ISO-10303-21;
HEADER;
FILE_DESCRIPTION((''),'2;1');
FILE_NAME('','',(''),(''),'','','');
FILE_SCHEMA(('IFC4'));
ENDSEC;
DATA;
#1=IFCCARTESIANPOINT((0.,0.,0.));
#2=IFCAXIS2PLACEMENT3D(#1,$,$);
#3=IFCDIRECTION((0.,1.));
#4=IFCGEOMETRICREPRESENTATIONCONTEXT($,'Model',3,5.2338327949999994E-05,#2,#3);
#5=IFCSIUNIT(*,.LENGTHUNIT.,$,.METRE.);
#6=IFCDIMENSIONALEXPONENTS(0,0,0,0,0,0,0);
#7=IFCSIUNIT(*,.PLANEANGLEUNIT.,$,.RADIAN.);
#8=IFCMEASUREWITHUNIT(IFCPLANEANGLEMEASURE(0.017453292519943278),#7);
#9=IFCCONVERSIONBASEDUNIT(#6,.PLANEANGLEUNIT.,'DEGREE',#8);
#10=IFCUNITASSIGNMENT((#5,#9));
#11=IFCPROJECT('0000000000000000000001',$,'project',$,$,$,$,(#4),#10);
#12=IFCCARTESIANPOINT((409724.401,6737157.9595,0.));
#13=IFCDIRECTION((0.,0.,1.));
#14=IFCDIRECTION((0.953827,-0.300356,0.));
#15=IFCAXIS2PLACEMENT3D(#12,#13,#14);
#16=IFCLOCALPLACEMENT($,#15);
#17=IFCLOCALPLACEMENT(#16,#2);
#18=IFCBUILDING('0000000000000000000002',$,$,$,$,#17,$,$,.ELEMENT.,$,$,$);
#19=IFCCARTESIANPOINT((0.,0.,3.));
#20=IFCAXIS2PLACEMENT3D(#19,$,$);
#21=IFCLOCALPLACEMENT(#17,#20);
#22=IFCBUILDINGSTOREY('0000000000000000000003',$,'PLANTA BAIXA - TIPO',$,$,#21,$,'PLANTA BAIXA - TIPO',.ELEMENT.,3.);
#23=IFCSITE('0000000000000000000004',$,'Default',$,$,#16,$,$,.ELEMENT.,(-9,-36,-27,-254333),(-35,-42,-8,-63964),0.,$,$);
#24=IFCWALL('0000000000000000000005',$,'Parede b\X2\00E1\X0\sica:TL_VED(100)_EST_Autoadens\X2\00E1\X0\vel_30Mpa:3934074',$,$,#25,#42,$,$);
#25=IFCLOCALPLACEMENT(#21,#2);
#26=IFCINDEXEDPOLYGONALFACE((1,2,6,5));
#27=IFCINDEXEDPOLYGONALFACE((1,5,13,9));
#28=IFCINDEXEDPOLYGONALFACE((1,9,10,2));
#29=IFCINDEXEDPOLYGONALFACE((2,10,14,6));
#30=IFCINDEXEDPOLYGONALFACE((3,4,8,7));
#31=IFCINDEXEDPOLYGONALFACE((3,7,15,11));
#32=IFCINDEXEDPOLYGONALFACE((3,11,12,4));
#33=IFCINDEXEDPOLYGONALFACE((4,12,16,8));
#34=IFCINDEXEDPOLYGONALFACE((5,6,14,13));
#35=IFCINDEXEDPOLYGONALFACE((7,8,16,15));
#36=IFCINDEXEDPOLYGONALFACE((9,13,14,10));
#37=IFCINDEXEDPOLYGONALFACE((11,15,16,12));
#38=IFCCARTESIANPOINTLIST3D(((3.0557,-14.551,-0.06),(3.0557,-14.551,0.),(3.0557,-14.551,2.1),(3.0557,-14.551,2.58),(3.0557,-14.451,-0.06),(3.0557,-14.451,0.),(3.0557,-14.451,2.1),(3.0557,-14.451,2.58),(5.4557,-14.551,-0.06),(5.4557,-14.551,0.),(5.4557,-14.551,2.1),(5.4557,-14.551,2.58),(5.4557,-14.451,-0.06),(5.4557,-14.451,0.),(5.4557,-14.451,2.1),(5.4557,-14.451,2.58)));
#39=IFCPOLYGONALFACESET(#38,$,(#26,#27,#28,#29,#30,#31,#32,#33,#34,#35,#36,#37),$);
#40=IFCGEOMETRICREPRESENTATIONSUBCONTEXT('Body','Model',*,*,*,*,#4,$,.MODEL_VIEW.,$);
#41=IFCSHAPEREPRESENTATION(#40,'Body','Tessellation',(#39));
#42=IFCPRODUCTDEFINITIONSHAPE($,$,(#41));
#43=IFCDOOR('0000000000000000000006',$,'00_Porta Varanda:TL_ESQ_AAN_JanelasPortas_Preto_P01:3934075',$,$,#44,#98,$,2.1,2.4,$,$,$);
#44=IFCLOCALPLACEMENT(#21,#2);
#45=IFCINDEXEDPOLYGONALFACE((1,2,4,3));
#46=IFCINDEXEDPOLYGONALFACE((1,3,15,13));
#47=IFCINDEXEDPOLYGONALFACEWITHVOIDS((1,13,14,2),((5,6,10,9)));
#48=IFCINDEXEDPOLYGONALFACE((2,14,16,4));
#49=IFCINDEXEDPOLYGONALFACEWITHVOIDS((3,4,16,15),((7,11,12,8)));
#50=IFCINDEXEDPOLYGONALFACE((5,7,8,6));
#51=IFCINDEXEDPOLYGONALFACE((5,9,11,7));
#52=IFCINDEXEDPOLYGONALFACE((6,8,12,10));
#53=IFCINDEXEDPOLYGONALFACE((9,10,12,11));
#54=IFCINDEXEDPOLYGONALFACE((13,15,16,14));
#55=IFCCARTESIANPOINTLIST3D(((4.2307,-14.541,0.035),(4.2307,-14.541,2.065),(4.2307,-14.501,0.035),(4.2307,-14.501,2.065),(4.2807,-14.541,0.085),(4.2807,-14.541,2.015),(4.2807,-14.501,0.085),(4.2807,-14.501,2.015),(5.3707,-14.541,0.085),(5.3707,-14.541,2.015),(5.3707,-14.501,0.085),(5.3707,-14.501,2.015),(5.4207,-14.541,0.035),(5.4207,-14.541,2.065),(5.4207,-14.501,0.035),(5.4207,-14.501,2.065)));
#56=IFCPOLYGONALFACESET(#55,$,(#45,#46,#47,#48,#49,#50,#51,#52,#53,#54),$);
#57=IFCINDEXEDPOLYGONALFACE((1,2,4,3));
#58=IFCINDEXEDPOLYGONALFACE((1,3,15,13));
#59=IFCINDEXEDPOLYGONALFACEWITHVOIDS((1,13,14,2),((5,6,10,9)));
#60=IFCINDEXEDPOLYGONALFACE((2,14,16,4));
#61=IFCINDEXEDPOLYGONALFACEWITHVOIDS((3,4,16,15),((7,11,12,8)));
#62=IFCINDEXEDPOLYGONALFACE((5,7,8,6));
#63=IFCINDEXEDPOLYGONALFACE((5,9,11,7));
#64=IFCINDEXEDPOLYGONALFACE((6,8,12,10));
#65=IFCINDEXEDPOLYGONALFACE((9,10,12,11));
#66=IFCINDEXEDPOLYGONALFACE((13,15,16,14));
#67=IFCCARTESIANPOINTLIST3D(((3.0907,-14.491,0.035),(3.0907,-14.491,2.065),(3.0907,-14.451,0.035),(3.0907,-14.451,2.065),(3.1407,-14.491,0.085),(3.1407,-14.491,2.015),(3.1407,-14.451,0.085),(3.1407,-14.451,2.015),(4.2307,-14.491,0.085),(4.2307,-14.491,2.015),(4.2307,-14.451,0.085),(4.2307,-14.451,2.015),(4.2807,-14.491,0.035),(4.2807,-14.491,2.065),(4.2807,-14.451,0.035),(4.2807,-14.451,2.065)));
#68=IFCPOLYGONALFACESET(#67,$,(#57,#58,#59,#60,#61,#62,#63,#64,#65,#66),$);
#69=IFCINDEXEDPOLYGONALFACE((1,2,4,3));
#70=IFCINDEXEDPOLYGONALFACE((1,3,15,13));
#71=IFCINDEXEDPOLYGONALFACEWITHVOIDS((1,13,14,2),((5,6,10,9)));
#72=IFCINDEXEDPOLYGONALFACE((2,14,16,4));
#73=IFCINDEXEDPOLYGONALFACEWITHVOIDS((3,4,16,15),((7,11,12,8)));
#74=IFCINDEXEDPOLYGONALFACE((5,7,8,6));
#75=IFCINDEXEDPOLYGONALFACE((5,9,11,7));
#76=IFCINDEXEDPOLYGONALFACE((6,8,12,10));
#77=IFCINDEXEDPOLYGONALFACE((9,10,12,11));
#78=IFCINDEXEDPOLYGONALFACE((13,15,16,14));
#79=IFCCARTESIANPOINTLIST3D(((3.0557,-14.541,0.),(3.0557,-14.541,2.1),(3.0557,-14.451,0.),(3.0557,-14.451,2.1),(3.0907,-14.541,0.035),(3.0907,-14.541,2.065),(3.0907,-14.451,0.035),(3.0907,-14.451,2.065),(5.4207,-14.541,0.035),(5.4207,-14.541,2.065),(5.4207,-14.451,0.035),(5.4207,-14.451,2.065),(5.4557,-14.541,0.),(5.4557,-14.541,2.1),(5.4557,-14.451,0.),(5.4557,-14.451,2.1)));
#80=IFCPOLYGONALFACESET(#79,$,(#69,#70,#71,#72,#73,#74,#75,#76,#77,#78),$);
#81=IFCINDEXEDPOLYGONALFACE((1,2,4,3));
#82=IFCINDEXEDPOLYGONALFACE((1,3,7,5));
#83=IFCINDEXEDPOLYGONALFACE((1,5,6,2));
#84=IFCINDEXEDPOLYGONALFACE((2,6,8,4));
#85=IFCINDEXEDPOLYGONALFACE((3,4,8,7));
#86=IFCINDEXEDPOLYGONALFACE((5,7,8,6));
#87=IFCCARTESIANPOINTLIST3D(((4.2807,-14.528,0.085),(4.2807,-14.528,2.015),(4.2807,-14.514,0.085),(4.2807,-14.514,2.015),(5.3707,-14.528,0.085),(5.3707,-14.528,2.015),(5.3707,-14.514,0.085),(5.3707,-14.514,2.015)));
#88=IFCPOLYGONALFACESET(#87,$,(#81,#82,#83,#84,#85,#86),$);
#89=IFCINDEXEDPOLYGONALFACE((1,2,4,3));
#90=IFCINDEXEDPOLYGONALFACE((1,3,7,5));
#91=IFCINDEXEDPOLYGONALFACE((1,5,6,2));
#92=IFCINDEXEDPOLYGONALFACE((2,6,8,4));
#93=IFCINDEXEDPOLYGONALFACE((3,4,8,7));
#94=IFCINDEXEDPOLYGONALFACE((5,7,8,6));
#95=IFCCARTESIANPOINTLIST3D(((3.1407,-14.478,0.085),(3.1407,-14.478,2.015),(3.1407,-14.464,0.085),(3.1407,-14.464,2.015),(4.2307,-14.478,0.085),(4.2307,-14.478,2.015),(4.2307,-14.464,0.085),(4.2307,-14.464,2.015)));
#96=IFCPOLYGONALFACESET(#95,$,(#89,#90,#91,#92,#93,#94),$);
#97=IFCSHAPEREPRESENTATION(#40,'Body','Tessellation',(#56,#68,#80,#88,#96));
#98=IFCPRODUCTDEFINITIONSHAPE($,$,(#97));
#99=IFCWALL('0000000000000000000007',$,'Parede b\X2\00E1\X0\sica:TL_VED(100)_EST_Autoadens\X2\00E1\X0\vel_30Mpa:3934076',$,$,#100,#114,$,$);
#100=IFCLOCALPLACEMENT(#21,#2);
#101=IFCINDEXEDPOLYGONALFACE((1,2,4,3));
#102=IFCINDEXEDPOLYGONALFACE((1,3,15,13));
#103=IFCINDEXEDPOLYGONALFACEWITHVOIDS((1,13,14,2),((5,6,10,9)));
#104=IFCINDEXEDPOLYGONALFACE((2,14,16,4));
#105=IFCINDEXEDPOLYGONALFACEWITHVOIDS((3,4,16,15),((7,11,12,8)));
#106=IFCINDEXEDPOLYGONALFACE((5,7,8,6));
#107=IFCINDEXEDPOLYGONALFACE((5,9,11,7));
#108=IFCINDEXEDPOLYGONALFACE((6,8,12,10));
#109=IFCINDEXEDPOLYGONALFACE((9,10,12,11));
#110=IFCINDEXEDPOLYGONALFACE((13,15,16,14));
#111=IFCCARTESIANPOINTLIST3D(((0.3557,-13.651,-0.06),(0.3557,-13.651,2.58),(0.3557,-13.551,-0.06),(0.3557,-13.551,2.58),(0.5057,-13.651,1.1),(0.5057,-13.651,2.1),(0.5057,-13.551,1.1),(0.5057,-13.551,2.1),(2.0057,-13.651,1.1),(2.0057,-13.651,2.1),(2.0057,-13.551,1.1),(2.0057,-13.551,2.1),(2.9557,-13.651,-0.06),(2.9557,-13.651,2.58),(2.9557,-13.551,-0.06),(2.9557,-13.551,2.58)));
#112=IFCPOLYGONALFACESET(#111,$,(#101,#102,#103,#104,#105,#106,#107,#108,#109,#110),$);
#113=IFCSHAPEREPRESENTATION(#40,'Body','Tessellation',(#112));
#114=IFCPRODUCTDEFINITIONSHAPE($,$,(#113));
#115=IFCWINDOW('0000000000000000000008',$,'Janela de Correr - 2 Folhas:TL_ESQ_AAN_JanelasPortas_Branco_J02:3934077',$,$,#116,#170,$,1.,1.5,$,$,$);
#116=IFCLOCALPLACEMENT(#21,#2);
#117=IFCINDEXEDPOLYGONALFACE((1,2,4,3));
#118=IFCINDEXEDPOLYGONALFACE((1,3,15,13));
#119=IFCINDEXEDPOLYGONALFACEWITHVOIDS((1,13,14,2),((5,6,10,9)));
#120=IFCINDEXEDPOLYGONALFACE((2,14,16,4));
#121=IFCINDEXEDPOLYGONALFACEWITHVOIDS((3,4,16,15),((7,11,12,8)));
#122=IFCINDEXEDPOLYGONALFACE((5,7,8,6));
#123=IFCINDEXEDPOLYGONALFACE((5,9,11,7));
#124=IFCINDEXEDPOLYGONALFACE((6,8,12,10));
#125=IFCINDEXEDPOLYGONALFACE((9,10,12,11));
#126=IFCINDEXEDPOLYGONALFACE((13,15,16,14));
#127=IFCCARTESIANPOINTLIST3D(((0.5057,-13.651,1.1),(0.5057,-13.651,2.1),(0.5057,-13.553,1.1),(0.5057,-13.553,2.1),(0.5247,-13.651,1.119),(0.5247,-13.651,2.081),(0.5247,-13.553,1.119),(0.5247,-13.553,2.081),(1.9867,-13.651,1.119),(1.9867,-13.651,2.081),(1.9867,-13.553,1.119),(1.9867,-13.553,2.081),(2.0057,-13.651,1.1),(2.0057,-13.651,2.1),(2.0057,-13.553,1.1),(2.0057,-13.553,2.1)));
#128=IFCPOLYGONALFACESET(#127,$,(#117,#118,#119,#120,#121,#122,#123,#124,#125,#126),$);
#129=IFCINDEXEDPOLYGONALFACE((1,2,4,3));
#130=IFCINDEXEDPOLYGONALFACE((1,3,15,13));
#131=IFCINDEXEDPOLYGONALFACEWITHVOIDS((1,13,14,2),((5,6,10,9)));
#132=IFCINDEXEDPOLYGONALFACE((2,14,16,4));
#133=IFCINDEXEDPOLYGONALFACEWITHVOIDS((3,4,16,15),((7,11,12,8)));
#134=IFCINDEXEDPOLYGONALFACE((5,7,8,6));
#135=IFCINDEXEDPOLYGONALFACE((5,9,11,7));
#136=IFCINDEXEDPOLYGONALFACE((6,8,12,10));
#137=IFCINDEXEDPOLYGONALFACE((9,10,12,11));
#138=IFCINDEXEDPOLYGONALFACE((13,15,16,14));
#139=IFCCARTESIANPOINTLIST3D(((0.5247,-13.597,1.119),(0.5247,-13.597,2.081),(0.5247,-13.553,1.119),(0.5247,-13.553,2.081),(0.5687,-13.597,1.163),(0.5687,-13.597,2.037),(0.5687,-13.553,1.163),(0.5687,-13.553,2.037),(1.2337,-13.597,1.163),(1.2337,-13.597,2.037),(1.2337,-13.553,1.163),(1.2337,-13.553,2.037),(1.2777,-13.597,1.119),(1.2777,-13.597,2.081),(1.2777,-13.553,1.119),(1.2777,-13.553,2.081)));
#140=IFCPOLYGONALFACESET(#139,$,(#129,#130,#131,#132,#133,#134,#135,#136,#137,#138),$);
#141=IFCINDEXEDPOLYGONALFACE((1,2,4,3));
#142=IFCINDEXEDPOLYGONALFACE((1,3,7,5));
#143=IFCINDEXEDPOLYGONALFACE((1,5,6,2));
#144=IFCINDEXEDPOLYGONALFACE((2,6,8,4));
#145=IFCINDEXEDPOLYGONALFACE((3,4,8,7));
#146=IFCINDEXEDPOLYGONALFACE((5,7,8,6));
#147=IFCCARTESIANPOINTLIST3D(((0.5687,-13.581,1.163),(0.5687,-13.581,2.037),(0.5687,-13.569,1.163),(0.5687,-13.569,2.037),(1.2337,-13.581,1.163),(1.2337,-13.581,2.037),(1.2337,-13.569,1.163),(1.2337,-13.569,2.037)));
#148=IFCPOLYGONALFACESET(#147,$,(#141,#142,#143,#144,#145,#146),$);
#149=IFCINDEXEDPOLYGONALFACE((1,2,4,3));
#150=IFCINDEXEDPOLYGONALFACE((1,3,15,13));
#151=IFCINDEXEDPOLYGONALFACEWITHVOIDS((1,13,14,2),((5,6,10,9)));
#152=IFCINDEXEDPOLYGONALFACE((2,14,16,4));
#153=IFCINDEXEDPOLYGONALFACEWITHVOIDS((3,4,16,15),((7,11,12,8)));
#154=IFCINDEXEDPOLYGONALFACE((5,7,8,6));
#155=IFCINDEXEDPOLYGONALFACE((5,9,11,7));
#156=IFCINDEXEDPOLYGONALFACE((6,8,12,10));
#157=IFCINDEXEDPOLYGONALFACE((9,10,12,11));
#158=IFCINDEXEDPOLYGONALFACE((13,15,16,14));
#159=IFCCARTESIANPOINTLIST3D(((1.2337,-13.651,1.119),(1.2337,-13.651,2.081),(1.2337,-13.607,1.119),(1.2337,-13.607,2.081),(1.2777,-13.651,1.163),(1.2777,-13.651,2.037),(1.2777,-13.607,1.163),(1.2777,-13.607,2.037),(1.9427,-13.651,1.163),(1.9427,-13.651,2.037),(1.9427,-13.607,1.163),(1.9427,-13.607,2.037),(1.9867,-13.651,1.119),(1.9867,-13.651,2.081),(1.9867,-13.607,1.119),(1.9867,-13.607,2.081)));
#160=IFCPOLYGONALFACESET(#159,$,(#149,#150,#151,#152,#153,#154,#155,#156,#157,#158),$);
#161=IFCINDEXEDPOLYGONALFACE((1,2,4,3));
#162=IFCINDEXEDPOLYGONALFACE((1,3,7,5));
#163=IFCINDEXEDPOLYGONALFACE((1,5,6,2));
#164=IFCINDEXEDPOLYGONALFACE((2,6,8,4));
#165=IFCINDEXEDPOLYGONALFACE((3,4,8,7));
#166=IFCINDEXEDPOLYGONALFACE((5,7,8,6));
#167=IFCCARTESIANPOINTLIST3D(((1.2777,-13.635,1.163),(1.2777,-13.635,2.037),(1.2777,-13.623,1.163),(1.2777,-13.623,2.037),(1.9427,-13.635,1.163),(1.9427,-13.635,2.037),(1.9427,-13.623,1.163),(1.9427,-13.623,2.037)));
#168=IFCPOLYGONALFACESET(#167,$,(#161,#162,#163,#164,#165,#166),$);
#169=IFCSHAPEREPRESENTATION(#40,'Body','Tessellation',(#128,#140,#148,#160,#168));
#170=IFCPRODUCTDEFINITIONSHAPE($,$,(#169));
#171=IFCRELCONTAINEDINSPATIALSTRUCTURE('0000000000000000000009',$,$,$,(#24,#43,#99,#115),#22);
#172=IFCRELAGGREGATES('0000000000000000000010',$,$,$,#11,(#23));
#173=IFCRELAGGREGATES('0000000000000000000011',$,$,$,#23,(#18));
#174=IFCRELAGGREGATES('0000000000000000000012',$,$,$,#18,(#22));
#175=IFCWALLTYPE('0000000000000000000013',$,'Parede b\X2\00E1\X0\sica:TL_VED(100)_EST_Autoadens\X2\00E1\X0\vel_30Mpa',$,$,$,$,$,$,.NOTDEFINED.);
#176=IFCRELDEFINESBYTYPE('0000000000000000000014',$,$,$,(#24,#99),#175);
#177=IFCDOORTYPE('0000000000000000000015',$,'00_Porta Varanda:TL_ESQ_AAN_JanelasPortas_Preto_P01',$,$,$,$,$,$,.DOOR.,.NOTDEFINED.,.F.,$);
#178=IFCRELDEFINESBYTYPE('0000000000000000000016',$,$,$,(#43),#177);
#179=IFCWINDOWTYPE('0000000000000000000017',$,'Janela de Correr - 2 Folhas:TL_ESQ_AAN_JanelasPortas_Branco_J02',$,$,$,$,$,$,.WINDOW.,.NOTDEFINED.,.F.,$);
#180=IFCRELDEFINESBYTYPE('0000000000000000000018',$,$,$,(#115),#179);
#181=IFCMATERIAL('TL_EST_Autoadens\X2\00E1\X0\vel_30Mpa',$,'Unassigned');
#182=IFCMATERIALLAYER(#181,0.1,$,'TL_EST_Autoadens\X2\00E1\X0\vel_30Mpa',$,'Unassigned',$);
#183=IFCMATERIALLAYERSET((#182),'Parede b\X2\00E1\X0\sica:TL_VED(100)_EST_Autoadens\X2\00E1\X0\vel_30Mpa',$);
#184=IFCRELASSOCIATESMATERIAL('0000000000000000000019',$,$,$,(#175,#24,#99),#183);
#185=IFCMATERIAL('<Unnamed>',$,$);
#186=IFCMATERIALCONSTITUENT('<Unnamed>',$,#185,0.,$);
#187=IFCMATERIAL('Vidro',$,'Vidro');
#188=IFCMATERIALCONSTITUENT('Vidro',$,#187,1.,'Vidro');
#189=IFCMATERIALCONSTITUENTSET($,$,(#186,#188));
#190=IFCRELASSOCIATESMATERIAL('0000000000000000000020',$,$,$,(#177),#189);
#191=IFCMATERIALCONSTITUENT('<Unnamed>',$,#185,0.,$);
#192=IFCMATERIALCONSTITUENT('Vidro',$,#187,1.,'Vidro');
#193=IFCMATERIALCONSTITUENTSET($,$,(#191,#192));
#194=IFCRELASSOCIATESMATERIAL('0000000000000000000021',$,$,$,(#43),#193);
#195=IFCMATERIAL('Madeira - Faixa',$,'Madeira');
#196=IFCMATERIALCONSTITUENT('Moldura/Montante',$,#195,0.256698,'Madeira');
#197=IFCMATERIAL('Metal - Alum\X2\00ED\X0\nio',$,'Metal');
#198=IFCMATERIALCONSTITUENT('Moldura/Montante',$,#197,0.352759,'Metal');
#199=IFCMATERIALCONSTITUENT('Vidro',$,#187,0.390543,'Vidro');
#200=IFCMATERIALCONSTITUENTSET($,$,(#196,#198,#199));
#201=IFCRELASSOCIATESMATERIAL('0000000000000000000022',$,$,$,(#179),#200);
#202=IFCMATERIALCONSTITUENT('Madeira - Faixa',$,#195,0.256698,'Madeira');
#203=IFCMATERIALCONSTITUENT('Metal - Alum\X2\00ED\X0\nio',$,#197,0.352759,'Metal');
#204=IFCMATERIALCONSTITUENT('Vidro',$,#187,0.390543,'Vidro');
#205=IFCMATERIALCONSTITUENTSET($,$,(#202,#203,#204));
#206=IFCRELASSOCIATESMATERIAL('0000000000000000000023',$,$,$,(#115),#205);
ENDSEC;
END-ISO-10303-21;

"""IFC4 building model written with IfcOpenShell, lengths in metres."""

from ifc_helpers import new_model, entity, si_unit, converted_unit, direction, frame, frame_2d, origin, origin_2d_with_axis, place, context, subcontext, project, spatial, polyline, rectangle, outline, extrude, source, transform, mapped, material, layer, layer_set, layer_usage, constituent, constituent_set, type_object, type_shapes, element, fill, save


model = new_model("IFC4")

# Units and contexts
model_context = context("Model", 3, precision=5.2338327949999994e-05, world=origin(), true_north=direction((0.0, 1.0)))
body_context = subcontext(model_context, "Body", "Model", "MODEL_VIEW")
ifc_project = project(units=[si_unit("LENGTHUNIT", "METRE"), converted_unit("PLANEANGLEUNIT", "DEGREE", entity("IfcPlaneAngleMeasure", 0.017453292519943278), si_unit("PLANEANGLEUNIT", "RADIAN"), dimensions=[0, 0, 0, 0, 0, 0, 0])], contexts=[model_context])

# Site, building, storey
site_placement = place(None, frame((409724.401, 6737157.9595, 0.0), z_axis=(0.0, 0.0, 1.0), x_axis=(0.953827, -0.300356, 0.0)))
site = spatial("IfcSite", under=ifc_project, at=site_placement, Name="Default", CompositionType="ELEMENT", RefLatitude=(-9, -36, -27, -254333), RefLongitude=(-35, -42, -8, -63964), RefElevation=0.0)
building_placement = place(site_placement, origin())
building = spatial("IfcBuilding", under=site, at=building_placement, CompositionType="ELEMENT")
storey_placement = place(building_placement, frame((0.0, 0.0, 3.0)))
storey = spatial("IfcBuildingStorey", under=building, at=storey_placement, Name="PLANTA BAIXA - TIPO", LongName="PLANTA BAIXA - TIPO", CompositionType="ELEMENT", Elevation=3.0)

# Shared definitions
ifc_material_1 = material(Name="TL_EST_Autoadensável_30Mpa", Category="Unassigned")
ifc_layer_1 = layer(ifc_material_1, 0.1, Name="TL_EST_Autoadensável_30Mpa", Category="Unassigned")
ifc_layer_set_1 = layer_set([ifc_layer_1], Name="Parede básica:TL_VED(100)_EST_Autoadensável_30Mpa")
wall_type_1 = type_object("IfcWallType", Name="Parede básica:TL_VED(100)_EST_Autoadensável_30Mpa", PredefinedType="NOTDEFINED", material=ifc_layer_set_1)

# Shared definitions
ifc_material_2 = material(Name="Madeira - Faixa", Category="Madeira")
ifc_material_3 = material(Name="Metal - Alumínio", Category="Metal")
ifc_material_4 = material(Name="Vidro", Category="Vidro")

# Wall, opening, door
ifc_layer_usage_1 = layer_usage(ifc_layer_set_1, "AXIS2", "NEGATIVE", 0.05)
wall_1_placement = place(storey_placement, frame((3.0557, -14.501, -0.06)))
wall_1 = element("IfcWall", 1, at=wall_1_placement, inside=storey, type_object=wall_type_1, material=ifc_layer_usage_1, Name="Parede básica:TL_VED(100)_EST_Autoadensável_30Mpa:3934074", context=body_context, shape_type="SweptSolid", body=[
    extrude(rectangle(XDim=2.4, YDim=0.1, at=frame_2d((1.2, 0.0), x_axis=(-1.0, 0.0))), origin(), (0.0, 0.0, 1.0), 2.64),
])
opening_1_placement = place(wall_1_placement, frame((2.4, 0.05, 0.06)))
opening_1 = element("IfcOpeningElement", 2, at=opening_1_placement, cuts=wall_1, PredefinedType="OPENING", context=body_context, shape_type="SweptSolid", body=[
    extrude(rectangle(XDim=2.1, YDim=2.4, at=frame_2d((1.05, 1.2), x_axis=(1.0, 0.0))), frame((0.0, 0.0, 0.0), z_axis=(0.0, -1.0, 0.0), x_axis=(0.0, 0.0, 1.0)), (0.0, 0.0, 1.0), 0.1),
])
ifc_material_5 = material(Name="<Unnamed>")
ifc_constituent_1 = constituent(ifc_material_5, Name="<Unnamed>", fraction=0.0)
ifc_constituent_2 = constituent(ifc_material_4, Name="Vidro", Category="Vidro", fraction=1.0)
ifc_constituent_set_1 = constituent_set(constituents=[ifc_constituent_1, ifc_constituent_2])
ifc_constituent_3 = constituent(ifc_material_5, Name="<Unnamed>", fraction=0.0)
ifc_constituent_4 = constituent(ifc_material_4, Name="Vidro", Category="Vidro", fraction=1.0)
ifc_constituent_set_2 = constituent_set(constituents=[ifc_constituent_3, ifc_constituent_4])
door_type = type_object("IfcDoorType", Name="00_Porta Varanda:TL_ESQ_AAN_JanelasPortas_Preto_P01", OperationType="NOTDEFINED", ParameterTakesPrecedence=False, PredefinedType="DOOR", material=ifc_constituent_set_2)
shared_shape_1 = source(origin(), body_context, "Body", "SweptSolid", [
    extrude(outline(polyline([(-0.595, -1.015), (0.595, -1.015), (0.595, 1.015), (-0.595, 1.015), (-0.595, -1.015)]), holes=[polyline([(-0.545, 0.965), (0.545, 0.965), (0.545, -0.965), (-0.545, -0.965), (-0.545, 0.965)])]), frame((0.63, 0.09, 1.05), z_axis=(0.0, -1.0, 0.0), x_axis=(-1.0, 0.0, 0.0)), (0.0, 0.0, 1.0), 0.04),
    extrude(outline(polyline([(-0.595, -1.015), (0.595, -1.015), (0.595, 1.015), (-0.595, 1.015), (-0.595, -1.015)]), holes=[polyline([(-0.545, 0.965), (0.545, 0.965), (0.545, -0.965), (-0.545, -0.965), (-0.545, 0.965)])]), frame((1.77, 0.04, 1.05), z_axis=(0.0, -1.0, 0.0), x_axis=(1.0, 0.0, 0.0)), (0.0, 0.0, 1.0), 0.04),
    extrude(outline(polyline([(-1.2, -1.05), (1.2, -1.05), (1.2, 1.05), (-1.2, 1.05), (-1.2, -1.05)]), holes=[polyline([(-1.165, 1.015), (1.165, 1.015), (1.165, -1.015), (-1.165, -1.015), (-1.165, 1.015)])]), frame((1.2, 0.09, 1.05), z_axis=(0.0, -1.0, 0.0), x_axis=(1.0, 0.0, 0.0)), (0.0, 0.0, 1.0), 0.09),
    extrude(rectangle(XDim=1.09, YDim=0.014, at=frame_2d((0.0, 0.0), x_axis=(1.0, 0.0))), frame((0.63, 0.07, 0.085), z_axis=(0.0, 0.0, 1.0), x_axis=(-1.0, 0.0, 0.0)), (0.0, 0.0, 1.0), 1.93),
    extrude(rectangle(XDim=1.09, YDim=0.014, at=frame_2d((0.0, 0.0), x_axis=(1.0, 0.0))), frame((1.77, 0.02, 0.085), z_axis=(0.0, 0.0, 1.0), x_axis=(-1.0, 0.0, 0.0)), (0.0, 0.0, 1.0), 1.93),
])
type_shapes(door_type, [shared_shape_1])
door_placement = place(opening_1_placement, frame((0.0, 0.0, 0.0), z_axis=(0.0, 0.0, 1.0), x_axis=(-1.0, 0.0, 0.0)))
door = element("IfcDoor", 3, at=door_placement, inside=storey, type_object=door_type, material=ifc_constituent_set_1, Name="00_Porta Varanda:TL_ESQ_AAN_JanelasPortas_Preto_P01:3934075", OverallHeight=2.1, OverallWidth=2.4, context=body_context, shape_type="MappedRepresentation", body=[
    mapped(shared_shape_1, transform((0.0, 0.0, 0.0), scale=1.0)),
])
fill(opening_1, door)

# Wall, opening, window
ifc_layer_usage_2 = layer_usage(ifc_layer_set_1, "AXIS2", "NEGATIVE", 0.05)
wall_2_placement = place(storey_placement, frame((0.3557, -13.601, -0.06)))
wall_2 = element("IfcWall", 4, at=wall_2_placement, inside=storey, type_object=wall_type_1, material=ifc_layer_usage_2, Name="Parede básica:TL_VED(100)_EST_Autoadensável_30Mpa:3934076", context=body_context, shape_type="SweptSolid", body=[
    extrude(rectangle(XDim=2.6, YDim=0.1, at=frame_2d((1.3, 0.0), x_axis=(-1.0, 0.0))), origin(), (0.0, 0.0, 1.0), 2.64),
])
opening_2_placement = place(wall_2_placement, frame((0.15, -0.05, 1.16)))
opening_2 = element("IfcOpeningElement", 5, at=opening_2_placement, cuts=wall_2, PredefinedType="OPENING", context=body_context, shape_type="SweptSolid", body=[
    extrude(rectangle(XDim=1.0, YDim=1.5, at=frame_2d((0.5, 0.75), x_axis=(-1.0, 0.0))), frame((0.0, 0.0, 0.0), z_axis=(0.0, 1.0, 0.0), x_axis=(0.0, 0.0, 1.0)), (0.0, 0.0, 1.0), 0.1),
])
ifc_constituent_5 = constituent(ifc_material_2, Name="Madeira - Faixa", Category="Madeira", fraction=0.256698)
ifc_constituent_6 = constituent(ifc_material_3, Name="Metal - Alumínio", Category="Metal", fraction=0.352759)
ifc_constituent_7 = constituent(ifc_material_4, Name="Vidro", Category="Vidro", fraction=0.390543)
ifc_constituent_set_3 = constituent_set(constituents=[ifc_constituent_5, ifc_constituent_6, ifc_constituent_7])
ifc_constituent_8 = constituent(ifc_material_2, Name="Moldura/Montante", Category="Madeira", fraction=0.256698)
ifc_constituent_9 = constituent(ifc_material_3, Name="Moldura/Montante", Category="Metal", fraction=0.352759)
ifc_constituent_10 = constituent(ifc_material_4, Name="Vidro", Category="Vidro", fraction=0.390543)
ifc_constituent_set_4 = constituent_set(constituents=[ifc_constituent_8, ifc_constituent_9, ifc_constituent_10])
window_type_1 = type_object("IfcWindowType", Name="Janela de Correr - 2 Folhas:TL_ESQ_AAN_JanelasPortas_Branco_J02", ParameterTakesPrecedence=False, PartitioningType="NOTDEFINED", PredefinedType="WINDOW", material=ifc_constituent_set_4)
shared_shape_2 = source(origin(), body_context, "Body", "SweptSolid", [
    extrude(outline(polyline([(-0.75, -0.5), (0.75, -0.5), (0.75, 0.5), (-0.75, 0.5), (-0.75, -0.5)]), holes=[polyline([(-0.731, -0.481), (-0.731, 0.481), (0.731, 0.481), (0.731, -0.481), (-0.731, -0.481)])]), frame((0.75, 0.124, 0.5), z_axis=(0.0, -1.0, 0.0), x_axis=(-1.0, 0.0, 0.0)), (0.0, 0.0, 1.0), 0.098),
    extrude(outline(polyline([(-0.3765, -0.481), (0.3765, -0.481), (0.3765, 0.481), (-0.3765, 0.481), (-0.3765, -0.481)]), holes=[polyline([(-0.3325, -0.437), (-0.3325, 0.437), (0.3325, 0.437), (0.3325, -0.437), (-0.3325, -0.437)])]), frame((0.3955, 0.124, 0.5), z_axis=(0.0, -1.0, 0.0), x_axis=(-1.0, 0.0, 0.0)), (0.0, 0.0, 1.0), 0.044),
    extrude(rectangle(XDim=0.665, YDim=0.012, at=origin_2d_with_axis()), frame((0.3955, 0.102, 0.063), z_axis=(0.0, 0.0, 1.0), x_axis=(-1.0, 0.0, 0.0)), (0.0, 0.0, 1.0), 0.874),
    extrude(outline(polyline([(-0.481, -0.3765), (0.481, -0.3765), (0.481, 0.3765), (-0.481, 0.3765), (-0.481, -0.3765)]), holes=[polyline([(-0.437, -0.3325), (-0.437, 0.3325), (0.437, 0.3325), (0.437, -0.3325), (-0.437, -0.3325)])]), frame((1.1045, 0.07, 0.5), z_axis=(0.0, -1.0, 0.0), x_axis=(0.0, 0.0, -1.0)), (0.0, 0.0, 1.0), 0.044),
    extrude(rectangle(XDim=0.665, YDim=0.012, at=origin_2d_with_axis()), frame((1.1045, 0.048, 0.063), z_axis=(0.0, 0.0, 1.0), x_axis=(-1.0, 0.0, 0.0)), (0.0, 0.0, 1.0), 0.874),
])
type_shapes(window_type_1, [shared_shape_2])
window_1_placement = place(opening_2_placement, frame((0.0, -0.026, 0.0)))
window_1 = element("IfcWindow", 6, at=window_1_placement, inside=storey, type_object=window_type_1, material=ifc_constituent_set_3, Name="Janela de Correr - 2 Folhas:TL_ESQ_AAN_JanelasPortas_Branco_J02:3934077", OverallHeight=1.0, OverallWidth=1.5, context=body_context, shape_type="MappedRepresentation", body=[
    mapped(shared_shape_2, transform((0.0, 0.0, 0.0), scale=1.0)),
])
fill(opening_2, window_1)

save(model, "model.ifc")
